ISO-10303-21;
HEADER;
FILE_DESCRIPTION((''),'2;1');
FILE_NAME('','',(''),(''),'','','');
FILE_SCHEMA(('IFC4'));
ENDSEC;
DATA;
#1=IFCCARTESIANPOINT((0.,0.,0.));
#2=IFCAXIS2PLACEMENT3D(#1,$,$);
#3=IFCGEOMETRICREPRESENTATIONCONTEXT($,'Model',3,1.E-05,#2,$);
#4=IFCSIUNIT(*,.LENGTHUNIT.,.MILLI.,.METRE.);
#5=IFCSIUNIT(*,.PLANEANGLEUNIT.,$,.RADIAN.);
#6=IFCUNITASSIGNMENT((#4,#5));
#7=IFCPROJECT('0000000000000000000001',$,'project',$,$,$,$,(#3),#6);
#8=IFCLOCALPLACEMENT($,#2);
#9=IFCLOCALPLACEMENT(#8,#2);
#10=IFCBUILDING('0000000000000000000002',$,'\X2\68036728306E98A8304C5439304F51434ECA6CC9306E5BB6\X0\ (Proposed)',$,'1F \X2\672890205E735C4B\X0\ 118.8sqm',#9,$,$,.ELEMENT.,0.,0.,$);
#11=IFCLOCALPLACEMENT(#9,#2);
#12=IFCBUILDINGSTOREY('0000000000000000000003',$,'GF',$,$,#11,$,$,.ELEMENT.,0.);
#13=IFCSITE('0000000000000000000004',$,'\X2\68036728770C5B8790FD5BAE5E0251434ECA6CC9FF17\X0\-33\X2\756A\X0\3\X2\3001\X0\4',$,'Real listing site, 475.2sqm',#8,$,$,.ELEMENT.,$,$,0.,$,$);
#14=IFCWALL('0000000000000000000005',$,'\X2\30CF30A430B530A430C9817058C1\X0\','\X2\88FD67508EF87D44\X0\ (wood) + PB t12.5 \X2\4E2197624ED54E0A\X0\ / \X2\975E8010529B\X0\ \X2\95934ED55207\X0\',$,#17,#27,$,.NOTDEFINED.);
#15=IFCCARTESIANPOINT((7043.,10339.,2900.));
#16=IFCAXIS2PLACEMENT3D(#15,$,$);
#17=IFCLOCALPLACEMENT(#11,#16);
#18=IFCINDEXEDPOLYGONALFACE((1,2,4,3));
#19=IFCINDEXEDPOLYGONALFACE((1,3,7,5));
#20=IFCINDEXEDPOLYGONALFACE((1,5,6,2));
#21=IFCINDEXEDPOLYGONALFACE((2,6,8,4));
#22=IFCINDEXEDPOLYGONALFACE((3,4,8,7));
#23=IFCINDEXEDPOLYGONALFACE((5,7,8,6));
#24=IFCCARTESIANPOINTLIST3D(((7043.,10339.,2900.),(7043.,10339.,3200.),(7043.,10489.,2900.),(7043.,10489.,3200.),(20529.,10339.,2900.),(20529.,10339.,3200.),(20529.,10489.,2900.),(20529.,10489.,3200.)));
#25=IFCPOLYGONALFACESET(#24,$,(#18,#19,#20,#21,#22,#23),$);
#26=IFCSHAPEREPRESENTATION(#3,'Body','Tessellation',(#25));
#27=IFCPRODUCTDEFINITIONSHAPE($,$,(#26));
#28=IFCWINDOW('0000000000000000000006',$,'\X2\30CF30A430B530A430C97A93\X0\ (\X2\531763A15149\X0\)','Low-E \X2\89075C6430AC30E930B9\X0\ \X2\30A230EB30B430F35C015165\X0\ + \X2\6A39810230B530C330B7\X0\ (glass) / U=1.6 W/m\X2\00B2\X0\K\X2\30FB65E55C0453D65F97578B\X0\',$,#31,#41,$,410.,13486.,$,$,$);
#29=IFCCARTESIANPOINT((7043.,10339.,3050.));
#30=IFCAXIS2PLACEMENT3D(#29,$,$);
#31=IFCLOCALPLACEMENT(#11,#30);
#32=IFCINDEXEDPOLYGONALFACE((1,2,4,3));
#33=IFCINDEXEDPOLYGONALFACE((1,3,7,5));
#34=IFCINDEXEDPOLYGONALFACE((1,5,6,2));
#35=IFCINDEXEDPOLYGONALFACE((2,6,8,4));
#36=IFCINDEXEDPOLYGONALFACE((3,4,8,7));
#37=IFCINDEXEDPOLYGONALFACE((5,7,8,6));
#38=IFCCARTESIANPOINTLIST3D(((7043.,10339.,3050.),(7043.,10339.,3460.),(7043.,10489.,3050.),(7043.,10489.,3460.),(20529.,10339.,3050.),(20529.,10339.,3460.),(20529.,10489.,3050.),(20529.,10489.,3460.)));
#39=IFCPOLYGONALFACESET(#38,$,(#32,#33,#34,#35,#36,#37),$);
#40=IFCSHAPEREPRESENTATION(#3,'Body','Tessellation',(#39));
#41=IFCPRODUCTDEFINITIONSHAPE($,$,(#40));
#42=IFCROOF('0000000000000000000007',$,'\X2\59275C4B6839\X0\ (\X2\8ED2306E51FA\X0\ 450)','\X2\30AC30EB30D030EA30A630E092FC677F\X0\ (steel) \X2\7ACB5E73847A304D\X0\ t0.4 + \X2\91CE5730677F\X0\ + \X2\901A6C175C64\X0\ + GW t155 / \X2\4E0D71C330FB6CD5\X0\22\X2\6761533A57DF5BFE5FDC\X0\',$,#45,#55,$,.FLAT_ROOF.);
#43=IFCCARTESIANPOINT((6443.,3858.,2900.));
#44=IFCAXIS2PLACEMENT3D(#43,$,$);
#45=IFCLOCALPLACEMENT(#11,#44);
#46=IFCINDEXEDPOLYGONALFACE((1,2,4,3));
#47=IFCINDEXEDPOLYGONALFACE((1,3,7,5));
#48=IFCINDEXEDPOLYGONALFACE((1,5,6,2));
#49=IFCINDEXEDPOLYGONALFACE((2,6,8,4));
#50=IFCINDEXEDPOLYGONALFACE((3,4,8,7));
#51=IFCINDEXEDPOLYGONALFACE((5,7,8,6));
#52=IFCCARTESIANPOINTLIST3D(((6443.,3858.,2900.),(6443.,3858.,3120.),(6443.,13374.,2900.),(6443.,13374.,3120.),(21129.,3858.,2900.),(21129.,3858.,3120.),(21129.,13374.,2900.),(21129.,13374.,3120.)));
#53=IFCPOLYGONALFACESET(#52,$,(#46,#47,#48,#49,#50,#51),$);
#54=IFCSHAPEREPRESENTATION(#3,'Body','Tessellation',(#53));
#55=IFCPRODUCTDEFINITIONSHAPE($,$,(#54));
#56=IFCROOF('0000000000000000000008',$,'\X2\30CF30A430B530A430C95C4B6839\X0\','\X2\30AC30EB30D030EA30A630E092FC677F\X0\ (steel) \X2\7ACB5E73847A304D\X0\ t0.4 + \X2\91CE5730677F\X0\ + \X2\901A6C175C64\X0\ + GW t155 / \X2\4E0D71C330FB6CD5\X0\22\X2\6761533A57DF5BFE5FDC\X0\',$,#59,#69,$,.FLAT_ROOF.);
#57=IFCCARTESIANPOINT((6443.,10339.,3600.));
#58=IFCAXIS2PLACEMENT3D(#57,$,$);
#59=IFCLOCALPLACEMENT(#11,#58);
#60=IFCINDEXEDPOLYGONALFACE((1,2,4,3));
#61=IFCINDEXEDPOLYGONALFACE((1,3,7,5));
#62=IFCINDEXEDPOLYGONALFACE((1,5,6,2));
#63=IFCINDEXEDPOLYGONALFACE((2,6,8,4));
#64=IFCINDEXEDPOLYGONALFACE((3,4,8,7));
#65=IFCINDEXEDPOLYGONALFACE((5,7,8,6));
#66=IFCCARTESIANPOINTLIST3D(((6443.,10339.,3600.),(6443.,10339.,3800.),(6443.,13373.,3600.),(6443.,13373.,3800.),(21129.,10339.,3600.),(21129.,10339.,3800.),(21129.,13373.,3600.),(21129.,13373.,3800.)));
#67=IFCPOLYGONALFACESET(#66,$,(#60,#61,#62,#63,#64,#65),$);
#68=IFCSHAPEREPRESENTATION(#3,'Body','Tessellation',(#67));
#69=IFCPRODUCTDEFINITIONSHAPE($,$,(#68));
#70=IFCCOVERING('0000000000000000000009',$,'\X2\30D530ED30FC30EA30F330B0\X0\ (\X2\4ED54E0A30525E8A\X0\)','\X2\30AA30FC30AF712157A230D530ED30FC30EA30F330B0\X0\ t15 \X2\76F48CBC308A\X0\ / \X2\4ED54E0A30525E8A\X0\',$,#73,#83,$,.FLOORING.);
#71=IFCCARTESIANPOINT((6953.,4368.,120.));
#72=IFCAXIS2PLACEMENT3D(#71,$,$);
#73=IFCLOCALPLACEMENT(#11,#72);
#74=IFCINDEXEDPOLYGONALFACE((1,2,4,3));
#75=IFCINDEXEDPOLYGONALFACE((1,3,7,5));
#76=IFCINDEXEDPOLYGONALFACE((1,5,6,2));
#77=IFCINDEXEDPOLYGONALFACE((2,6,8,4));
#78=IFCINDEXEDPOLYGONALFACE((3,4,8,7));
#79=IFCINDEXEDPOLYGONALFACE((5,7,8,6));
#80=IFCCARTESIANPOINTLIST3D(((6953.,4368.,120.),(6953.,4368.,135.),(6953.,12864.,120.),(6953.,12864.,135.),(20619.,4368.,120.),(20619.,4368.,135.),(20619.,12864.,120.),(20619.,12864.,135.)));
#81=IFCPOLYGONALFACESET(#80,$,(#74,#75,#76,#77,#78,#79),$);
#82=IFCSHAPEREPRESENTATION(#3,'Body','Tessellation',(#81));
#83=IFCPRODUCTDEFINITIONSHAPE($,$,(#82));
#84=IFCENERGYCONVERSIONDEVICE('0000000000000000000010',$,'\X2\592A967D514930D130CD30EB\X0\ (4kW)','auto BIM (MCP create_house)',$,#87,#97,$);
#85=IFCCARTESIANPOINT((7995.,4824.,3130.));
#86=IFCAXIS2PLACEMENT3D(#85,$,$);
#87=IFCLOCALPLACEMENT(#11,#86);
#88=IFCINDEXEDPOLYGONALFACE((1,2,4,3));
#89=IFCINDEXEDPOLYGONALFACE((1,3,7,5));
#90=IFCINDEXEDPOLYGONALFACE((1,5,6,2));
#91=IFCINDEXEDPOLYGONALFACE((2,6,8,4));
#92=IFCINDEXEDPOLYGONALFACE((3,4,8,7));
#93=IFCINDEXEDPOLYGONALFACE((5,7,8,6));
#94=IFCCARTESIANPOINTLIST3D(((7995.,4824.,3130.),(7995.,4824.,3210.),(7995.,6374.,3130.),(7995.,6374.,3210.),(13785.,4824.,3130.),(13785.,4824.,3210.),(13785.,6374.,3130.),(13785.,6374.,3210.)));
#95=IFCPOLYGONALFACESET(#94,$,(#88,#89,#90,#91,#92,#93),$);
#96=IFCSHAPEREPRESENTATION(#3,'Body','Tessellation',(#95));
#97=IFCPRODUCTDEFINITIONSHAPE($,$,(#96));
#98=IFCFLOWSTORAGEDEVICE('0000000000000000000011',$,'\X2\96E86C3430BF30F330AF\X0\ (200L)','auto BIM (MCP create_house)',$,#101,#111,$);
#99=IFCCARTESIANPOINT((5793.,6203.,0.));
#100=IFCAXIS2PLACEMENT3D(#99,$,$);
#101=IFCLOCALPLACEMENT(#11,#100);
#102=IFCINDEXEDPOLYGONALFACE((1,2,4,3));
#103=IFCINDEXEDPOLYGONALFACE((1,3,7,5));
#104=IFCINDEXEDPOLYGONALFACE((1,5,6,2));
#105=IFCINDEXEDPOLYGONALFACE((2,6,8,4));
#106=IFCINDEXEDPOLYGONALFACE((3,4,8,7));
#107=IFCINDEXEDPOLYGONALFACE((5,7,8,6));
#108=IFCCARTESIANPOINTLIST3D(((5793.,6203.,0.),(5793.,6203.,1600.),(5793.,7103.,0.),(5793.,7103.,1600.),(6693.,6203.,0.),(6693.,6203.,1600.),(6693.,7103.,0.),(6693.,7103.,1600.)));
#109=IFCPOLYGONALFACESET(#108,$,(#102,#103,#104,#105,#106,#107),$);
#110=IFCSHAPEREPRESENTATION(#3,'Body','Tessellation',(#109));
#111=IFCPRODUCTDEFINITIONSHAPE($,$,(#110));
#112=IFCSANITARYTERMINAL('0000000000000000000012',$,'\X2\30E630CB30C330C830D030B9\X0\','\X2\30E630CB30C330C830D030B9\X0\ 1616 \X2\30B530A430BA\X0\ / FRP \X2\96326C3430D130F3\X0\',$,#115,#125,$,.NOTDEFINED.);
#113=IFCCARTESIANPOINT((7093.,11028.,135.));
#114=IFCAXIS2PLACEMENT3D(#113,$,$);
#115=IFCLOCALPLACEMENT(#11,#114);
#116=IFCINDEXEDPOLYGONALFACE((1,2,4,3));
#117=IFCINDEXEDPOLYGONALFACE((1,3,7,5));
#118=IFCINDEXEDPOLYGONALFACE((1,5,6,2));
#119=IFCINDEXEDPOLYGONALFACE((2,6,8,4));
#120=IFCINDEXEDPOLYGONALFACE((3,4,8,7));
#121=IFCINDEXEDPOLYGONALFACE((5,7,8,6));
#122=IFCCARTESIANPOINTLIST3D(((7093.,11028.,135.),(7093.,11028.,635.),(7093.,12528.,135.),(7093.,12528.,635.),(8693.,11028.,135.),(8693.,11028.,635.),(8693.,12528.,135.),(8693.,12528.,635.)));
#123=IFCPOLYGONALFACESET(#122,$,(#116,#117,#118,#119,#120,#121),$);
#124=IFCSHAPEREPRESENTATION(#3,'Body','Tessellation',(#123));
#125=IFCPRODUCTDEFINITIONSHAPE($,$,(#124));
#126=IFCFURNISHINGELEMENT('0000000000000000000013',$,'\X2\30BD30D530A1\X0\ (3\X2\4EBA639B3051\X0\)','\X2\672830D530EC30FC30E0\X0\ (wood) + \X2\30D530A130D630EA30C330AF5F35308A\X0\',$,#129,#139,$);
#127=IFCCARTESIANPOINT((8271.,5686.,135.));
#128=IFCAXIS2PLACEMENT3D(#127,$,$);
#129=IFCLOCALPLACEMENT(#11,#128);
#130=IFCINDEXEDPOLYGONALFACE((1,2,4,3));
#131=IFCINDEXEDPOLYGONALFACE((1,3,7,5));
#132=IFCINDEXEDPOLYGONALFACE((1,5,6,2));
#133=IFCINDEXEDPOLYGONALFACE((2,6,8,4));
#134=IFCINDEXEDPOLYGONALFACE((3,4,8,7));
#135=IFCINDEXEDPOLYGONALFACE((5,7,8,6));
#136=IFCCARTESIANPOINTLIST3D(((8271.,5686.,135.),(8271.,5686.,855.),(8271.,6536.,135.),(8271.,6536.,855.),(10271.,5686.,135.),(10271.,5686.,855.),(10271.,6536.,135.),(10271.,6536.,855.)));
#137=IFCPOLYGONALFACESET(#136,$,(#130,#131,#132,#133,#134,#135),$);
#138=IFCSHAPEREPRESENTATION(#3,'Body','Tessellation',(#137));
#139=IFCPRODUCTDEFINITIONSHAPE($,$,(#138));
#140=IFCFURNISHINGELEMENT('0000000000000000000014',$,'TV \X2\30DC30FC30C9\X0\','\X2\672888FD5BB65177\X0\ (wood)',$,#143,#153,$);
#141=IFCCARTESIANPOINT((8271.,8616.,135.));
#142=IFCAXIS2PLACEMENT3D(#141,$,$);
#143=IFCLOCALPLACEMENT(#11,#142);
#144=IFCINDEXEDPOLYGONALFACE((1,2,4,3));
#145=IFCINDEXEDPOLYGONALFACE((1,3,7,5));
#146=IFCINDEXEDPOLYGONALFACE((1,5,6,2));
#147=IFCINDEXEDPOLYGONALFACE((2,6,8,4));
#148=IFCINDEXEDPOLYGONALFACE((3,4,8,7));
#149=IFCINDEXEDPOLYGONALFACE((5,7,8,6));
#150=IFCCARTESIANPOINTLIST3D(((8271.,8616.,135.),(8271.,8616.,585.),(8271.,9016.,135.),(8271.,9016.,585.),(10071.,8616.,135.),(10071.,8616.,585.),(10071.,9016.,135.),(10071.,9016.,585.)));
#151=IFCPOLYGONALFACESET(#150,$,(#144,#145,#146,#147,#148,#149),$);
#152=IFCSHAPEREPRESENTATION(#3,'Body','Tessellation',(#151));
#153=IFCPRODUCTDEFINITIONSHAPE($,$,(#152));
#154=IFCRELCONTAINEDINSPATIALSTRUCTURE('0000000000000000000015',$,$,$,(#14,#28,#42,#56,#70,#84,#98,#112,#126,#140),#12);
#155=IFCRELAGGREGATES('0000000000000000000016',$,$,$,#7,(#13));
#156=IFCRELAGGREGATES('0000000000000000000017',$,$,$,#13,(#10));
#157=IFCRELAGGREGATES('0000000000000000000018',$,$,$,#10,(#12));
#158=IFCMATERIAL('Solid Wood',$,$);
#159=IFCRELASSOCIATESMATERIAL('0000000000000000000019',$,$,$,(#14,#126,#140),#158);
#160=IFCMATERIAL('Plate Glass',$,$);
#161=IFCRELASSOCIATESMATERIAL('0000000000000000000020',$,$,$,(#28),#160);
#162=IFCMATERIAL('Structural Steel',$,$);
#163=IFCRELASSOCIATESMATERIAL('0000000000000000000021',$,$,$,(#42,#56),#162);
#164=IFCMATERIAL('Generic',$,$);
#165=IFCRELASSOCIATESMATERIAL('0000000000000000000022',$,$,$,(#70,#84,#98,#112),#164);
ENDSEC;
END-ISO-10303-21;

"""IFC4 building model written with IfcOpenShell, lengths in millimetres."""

from ifc_helpers import new_model, si_unit, frame, frame_2d, origin, place, context, project, spatial, rectangle, extrude, material, element, fill, save


model = new_model("IFC4")

# Units and contexts
model_context = context("Model", 3, precision=1e-05, world=origin())
ifc_project = project(units=[si_unit("LENGTHUNIT", "METRE", prefix="MILLI"), si_unit("PLANEANGLEUNIT", "RADIAN")], contexts=[model_context])

# Site, building, storey
site_placement = place(None, origin())
site = spatial("IfcSite", under=ifc_project, at=site_placement, Name="栃木県宇都宮市元今泉７-33番3、4", ObjectType="Real listing site, 475.2sqm", CompositionType="ELEMENT", RefElevation=0.0)
building_placement = place(site_placement, origin())
building = spatial("IfcBuilding", under=site, at=building_placement, Name="栃木の風が吹く元今泉の家 (Proposed)", ObjectType="1F 木造平屋 118.8sqm", CompositionType="ELEMENT", ElevationOfRefHeight=0.0, ElevationOfTerrain=0.0)
storey_placement = place(building_placement, origin())
storey = spatial("IfcBuildingStorey", under=building, at=storey_placement, Name="GF", CompositionType="ELEMENT", Elevation=0.0)

# Shared definitions
ifc_material_1 = material(Name="Solid Wood")

# Shared definitions
ifc_material_2 = material(Name="Plate Glass")

# Wall, opening, window
wall_1_placement = place(storey_placement, frame((7043.0, 10339.0, 2900.0)))
wall_1 = element("IfcWall", 1, at=wall_1_placement, inside=storey, material=ifc_material_1, Name="ハイサイド腰壁", Description="製材軸組 (wood) + PB t12.5 両面仕上 / 非耐力 間仕切", PredefinedType="NOTDEFINED", context=model_context, shape_type="SweptSolid", body=[
    extrude(rectangle(XDim=13486.0, YDim=150.0, at=frame_2d((6743.0, 75.0))), frame((7043.0, 10339.0, 2900.0)), (0.0, 0.0, 1.0), 700.0),
])
opening_1_placement = place(storey_placement, frame((7043.0, 10339.0, 3050.0)))
opening_1 = element("IfcOpeningElement", 2, at=opening_1_placement, cuts=wall_1, PredefinedType="NOTDEFINED", context=model_context, shape_type="SweptSolid", body=[
    extrude(rectangle(XDim=13486.0, YDim=150.0, at=frame_2d((6743.0, 75.0))), frame((7043.0, 10339.0, 3050.0)), (0.0, 0.0, 1.0), 410.0),
])
window_1_placement = place(storey_placement, frame((7043.0, 10339.0, 3050.0)))
window_1 = element("IfcWindow", 3, at=window_1_placement, inside=storey, material=ifc_material_2, Name="ハイサイド窓 (北採光)", Description="Low-E 複層ガラス アルゴン封入 + 樹脂サッシ (glass) / U=1.6 W/m²K・日射取得型", OverallHeight=410.0, OverallWidth=13486.0, context=model_context, shape_type="SweptSolid", body=[
    extrude(rectangle(XDim=13486.0, YDim=150.0, at=frame_2d((6743.0, 75.0))), frame((7043.0, 10339.0, 3050.0)), (0.0, 0.0, 1.0), 410.0),
])
fill(opening_1, window_1)

# Roofs
ifc_material_3 = material(Name="Structural Steel")
roof_1_placement = place(storey_placement, frame((6443.0, 3858.0, 2900.0)))
element("IfcRoof", 4, at=roof_1_placement, inside=storey, material=ifc_material_3, Name="大屋根 (軒の出 450)", Description="ガルバリウム鋼板 (steel) 立平葺き t0.4 + 野地板 + 通気層 + GW t155 / 不燃・法22条区域対応", PredefinedType="FLAT_ROOF", context=model_context, shape_type="SweptSolid", body=[
    extrude(rectangle(XDim=14686.0, YDim=9516.0, at=frame_2d((7343.0, 4758.0))), frame((6443.0, 3858.0, 2900.0)), (0.0, 0.0, 1.0), 220.0),
])
roof_2_placement = place(storey_placement, frame((6443.0, 10339.0, 3600.0)))
element("IfcRoof", 5, at=roof_2_placement, inside=storey, material=ifc_material_3, Name="ハイサイド屋根", Description="ガルバリウム鋼板 (steel) 立平葺き t0.4 + 野地板 + 通気層 + GW t155 / 不燃・法22条区域対応", PredefinedType="FLAT_ROOF", context=model_context, shape_type="SweptSolid", body=[
    extrude(rectangle(XDim=14686.0, YDim=3034.0, at=frame_2d((7343.0, 1517.0))), frame((6443.0, 10339.0, 3600.0)), (0.0, 0.0, 1.0), 200.0),
])

# Covering
ifc_material_4 = material(Name="Generic")
covering_placement = place(storey_placement, frame((6953.0, 4368.0, 120.0)))
element("IfcCovering", 6, at=covering_placement, inside=storey, material=ifc_material_4, Name="フローリング (仕上げ床)", Description="オーク無垢フローリング t15 直貼り / 仕上げ床", PredefinedType="FLOORING", context=model_context, shape_type="SweptSolid", body=[
    extrude(rectangle(XDim=13666.0, YDim=8496.0, at=frame_2d((6833.0, 4248.0))), frame((6953.0, 4368.0, 120.0)), (0.0, 0.0, 1.0), 15.0),
])

# Energy conversion device
energy_conversion_device_placement = place(storey_placement, frame((7995.0, 4824.0, 3130.0)))
element("IfcEnergyConversionDevice", 7, at=energy_conversion_device_placement, inside=storey, material=ifc_material_4, Name="太陽光パネル (4kW)", Description="auto BIM (MCP create_house)", context=model_context, shape_type="SweptSolid", body=[
    extrude(rectangle(XDim=5790.0, YDim=1550.0, at=frame_2d((2895.0, 775.0))), frame((7995.0, 4824.0, 3130.0)), (0.0, 0.0, 1.0), 80.0),
])

# Flow storage device
flow_storage_device_placement = place(storey_placement, frame((5793.0, 6203.0, 0.0)))
element("IfcFlowStorageDevice", 8, at=flow_storage_device_placement, inside=storey, material=ifc_material_4, Name="雨水タンク (200L)", Description="auto BIM (MCP create_house)", context=model_context, shape_type="SweptSolid", body=[
    extrude(rectangle(XDim=900.0, YDim=900.0, at=frame_2d((450.0, 450.0))), frame((5793.0, 6203.0, 0.0)), (0.0, 0.0, 1.0), 1600.0),
])

# Sanitary terminal
sanitary_terminal_placement = place(storey_placement, frame((7093.0, 11028.0, 135.0)))
element("IfcSanitaryTerminal", 9, at=sanitary_terminal_placement, inside=storey, material=ifc_material_4, Name="ユニットバス", Description="ユニットバス 1616 サイズ / FRP 防水パン", PredefinedType="NOTDEFINED", context=model_context, shape_type="SweptSolid", body=[
    extrude(rectangle(XDim=1600.0, YDim=1500.0, at=frame_2d((800.0, 750.0))), frame((7093.0, 11028.0, 135.0)), (0.0, 0.0, 1.0), 500.0),
])

# Furnishing elements
furnishing_1_placement = place(storey_placement, frame((8271.0, 5686.0, 135.0)))
element("IfcFurnishingElement", 10, at=furnishing_1_placement, inside=storey, material=ifc_material_1, Name="ソファ (3人掛け)", Description="木フレーム (wood) + ファブリック張り", context=model_context, shape_type="SweptSolid", body=[
    extrude(rectangle(XDim=2000.0, YDim=850.0, at=frame_2d((1000.0, 425.0))), frame((8271.0, 5686.0, 135.0)), (0.0, 0.0, 1.0), 720.0),
])
furnishing_2_placement = place(storey_placement, frame((8271.0, 8616.0, 135.0)))
element("IfcFurnishingElement", 11, at=furnishing_2_placement, inside=storey, material=ifc_material_1, Name="TV ボード", Description="木製家具 (wood)", context=model_context, shape_type="SweptSolid", body=[
    extrude(rectangle(XDim=1800.0, YDim=400.0, at=frame_2d((900.0, 200.0))), frame((8271.0, 8616.0, 135.0)), (0.0, 0.0, 1.0), 450.0),
])

save(model, "model.ifc")
